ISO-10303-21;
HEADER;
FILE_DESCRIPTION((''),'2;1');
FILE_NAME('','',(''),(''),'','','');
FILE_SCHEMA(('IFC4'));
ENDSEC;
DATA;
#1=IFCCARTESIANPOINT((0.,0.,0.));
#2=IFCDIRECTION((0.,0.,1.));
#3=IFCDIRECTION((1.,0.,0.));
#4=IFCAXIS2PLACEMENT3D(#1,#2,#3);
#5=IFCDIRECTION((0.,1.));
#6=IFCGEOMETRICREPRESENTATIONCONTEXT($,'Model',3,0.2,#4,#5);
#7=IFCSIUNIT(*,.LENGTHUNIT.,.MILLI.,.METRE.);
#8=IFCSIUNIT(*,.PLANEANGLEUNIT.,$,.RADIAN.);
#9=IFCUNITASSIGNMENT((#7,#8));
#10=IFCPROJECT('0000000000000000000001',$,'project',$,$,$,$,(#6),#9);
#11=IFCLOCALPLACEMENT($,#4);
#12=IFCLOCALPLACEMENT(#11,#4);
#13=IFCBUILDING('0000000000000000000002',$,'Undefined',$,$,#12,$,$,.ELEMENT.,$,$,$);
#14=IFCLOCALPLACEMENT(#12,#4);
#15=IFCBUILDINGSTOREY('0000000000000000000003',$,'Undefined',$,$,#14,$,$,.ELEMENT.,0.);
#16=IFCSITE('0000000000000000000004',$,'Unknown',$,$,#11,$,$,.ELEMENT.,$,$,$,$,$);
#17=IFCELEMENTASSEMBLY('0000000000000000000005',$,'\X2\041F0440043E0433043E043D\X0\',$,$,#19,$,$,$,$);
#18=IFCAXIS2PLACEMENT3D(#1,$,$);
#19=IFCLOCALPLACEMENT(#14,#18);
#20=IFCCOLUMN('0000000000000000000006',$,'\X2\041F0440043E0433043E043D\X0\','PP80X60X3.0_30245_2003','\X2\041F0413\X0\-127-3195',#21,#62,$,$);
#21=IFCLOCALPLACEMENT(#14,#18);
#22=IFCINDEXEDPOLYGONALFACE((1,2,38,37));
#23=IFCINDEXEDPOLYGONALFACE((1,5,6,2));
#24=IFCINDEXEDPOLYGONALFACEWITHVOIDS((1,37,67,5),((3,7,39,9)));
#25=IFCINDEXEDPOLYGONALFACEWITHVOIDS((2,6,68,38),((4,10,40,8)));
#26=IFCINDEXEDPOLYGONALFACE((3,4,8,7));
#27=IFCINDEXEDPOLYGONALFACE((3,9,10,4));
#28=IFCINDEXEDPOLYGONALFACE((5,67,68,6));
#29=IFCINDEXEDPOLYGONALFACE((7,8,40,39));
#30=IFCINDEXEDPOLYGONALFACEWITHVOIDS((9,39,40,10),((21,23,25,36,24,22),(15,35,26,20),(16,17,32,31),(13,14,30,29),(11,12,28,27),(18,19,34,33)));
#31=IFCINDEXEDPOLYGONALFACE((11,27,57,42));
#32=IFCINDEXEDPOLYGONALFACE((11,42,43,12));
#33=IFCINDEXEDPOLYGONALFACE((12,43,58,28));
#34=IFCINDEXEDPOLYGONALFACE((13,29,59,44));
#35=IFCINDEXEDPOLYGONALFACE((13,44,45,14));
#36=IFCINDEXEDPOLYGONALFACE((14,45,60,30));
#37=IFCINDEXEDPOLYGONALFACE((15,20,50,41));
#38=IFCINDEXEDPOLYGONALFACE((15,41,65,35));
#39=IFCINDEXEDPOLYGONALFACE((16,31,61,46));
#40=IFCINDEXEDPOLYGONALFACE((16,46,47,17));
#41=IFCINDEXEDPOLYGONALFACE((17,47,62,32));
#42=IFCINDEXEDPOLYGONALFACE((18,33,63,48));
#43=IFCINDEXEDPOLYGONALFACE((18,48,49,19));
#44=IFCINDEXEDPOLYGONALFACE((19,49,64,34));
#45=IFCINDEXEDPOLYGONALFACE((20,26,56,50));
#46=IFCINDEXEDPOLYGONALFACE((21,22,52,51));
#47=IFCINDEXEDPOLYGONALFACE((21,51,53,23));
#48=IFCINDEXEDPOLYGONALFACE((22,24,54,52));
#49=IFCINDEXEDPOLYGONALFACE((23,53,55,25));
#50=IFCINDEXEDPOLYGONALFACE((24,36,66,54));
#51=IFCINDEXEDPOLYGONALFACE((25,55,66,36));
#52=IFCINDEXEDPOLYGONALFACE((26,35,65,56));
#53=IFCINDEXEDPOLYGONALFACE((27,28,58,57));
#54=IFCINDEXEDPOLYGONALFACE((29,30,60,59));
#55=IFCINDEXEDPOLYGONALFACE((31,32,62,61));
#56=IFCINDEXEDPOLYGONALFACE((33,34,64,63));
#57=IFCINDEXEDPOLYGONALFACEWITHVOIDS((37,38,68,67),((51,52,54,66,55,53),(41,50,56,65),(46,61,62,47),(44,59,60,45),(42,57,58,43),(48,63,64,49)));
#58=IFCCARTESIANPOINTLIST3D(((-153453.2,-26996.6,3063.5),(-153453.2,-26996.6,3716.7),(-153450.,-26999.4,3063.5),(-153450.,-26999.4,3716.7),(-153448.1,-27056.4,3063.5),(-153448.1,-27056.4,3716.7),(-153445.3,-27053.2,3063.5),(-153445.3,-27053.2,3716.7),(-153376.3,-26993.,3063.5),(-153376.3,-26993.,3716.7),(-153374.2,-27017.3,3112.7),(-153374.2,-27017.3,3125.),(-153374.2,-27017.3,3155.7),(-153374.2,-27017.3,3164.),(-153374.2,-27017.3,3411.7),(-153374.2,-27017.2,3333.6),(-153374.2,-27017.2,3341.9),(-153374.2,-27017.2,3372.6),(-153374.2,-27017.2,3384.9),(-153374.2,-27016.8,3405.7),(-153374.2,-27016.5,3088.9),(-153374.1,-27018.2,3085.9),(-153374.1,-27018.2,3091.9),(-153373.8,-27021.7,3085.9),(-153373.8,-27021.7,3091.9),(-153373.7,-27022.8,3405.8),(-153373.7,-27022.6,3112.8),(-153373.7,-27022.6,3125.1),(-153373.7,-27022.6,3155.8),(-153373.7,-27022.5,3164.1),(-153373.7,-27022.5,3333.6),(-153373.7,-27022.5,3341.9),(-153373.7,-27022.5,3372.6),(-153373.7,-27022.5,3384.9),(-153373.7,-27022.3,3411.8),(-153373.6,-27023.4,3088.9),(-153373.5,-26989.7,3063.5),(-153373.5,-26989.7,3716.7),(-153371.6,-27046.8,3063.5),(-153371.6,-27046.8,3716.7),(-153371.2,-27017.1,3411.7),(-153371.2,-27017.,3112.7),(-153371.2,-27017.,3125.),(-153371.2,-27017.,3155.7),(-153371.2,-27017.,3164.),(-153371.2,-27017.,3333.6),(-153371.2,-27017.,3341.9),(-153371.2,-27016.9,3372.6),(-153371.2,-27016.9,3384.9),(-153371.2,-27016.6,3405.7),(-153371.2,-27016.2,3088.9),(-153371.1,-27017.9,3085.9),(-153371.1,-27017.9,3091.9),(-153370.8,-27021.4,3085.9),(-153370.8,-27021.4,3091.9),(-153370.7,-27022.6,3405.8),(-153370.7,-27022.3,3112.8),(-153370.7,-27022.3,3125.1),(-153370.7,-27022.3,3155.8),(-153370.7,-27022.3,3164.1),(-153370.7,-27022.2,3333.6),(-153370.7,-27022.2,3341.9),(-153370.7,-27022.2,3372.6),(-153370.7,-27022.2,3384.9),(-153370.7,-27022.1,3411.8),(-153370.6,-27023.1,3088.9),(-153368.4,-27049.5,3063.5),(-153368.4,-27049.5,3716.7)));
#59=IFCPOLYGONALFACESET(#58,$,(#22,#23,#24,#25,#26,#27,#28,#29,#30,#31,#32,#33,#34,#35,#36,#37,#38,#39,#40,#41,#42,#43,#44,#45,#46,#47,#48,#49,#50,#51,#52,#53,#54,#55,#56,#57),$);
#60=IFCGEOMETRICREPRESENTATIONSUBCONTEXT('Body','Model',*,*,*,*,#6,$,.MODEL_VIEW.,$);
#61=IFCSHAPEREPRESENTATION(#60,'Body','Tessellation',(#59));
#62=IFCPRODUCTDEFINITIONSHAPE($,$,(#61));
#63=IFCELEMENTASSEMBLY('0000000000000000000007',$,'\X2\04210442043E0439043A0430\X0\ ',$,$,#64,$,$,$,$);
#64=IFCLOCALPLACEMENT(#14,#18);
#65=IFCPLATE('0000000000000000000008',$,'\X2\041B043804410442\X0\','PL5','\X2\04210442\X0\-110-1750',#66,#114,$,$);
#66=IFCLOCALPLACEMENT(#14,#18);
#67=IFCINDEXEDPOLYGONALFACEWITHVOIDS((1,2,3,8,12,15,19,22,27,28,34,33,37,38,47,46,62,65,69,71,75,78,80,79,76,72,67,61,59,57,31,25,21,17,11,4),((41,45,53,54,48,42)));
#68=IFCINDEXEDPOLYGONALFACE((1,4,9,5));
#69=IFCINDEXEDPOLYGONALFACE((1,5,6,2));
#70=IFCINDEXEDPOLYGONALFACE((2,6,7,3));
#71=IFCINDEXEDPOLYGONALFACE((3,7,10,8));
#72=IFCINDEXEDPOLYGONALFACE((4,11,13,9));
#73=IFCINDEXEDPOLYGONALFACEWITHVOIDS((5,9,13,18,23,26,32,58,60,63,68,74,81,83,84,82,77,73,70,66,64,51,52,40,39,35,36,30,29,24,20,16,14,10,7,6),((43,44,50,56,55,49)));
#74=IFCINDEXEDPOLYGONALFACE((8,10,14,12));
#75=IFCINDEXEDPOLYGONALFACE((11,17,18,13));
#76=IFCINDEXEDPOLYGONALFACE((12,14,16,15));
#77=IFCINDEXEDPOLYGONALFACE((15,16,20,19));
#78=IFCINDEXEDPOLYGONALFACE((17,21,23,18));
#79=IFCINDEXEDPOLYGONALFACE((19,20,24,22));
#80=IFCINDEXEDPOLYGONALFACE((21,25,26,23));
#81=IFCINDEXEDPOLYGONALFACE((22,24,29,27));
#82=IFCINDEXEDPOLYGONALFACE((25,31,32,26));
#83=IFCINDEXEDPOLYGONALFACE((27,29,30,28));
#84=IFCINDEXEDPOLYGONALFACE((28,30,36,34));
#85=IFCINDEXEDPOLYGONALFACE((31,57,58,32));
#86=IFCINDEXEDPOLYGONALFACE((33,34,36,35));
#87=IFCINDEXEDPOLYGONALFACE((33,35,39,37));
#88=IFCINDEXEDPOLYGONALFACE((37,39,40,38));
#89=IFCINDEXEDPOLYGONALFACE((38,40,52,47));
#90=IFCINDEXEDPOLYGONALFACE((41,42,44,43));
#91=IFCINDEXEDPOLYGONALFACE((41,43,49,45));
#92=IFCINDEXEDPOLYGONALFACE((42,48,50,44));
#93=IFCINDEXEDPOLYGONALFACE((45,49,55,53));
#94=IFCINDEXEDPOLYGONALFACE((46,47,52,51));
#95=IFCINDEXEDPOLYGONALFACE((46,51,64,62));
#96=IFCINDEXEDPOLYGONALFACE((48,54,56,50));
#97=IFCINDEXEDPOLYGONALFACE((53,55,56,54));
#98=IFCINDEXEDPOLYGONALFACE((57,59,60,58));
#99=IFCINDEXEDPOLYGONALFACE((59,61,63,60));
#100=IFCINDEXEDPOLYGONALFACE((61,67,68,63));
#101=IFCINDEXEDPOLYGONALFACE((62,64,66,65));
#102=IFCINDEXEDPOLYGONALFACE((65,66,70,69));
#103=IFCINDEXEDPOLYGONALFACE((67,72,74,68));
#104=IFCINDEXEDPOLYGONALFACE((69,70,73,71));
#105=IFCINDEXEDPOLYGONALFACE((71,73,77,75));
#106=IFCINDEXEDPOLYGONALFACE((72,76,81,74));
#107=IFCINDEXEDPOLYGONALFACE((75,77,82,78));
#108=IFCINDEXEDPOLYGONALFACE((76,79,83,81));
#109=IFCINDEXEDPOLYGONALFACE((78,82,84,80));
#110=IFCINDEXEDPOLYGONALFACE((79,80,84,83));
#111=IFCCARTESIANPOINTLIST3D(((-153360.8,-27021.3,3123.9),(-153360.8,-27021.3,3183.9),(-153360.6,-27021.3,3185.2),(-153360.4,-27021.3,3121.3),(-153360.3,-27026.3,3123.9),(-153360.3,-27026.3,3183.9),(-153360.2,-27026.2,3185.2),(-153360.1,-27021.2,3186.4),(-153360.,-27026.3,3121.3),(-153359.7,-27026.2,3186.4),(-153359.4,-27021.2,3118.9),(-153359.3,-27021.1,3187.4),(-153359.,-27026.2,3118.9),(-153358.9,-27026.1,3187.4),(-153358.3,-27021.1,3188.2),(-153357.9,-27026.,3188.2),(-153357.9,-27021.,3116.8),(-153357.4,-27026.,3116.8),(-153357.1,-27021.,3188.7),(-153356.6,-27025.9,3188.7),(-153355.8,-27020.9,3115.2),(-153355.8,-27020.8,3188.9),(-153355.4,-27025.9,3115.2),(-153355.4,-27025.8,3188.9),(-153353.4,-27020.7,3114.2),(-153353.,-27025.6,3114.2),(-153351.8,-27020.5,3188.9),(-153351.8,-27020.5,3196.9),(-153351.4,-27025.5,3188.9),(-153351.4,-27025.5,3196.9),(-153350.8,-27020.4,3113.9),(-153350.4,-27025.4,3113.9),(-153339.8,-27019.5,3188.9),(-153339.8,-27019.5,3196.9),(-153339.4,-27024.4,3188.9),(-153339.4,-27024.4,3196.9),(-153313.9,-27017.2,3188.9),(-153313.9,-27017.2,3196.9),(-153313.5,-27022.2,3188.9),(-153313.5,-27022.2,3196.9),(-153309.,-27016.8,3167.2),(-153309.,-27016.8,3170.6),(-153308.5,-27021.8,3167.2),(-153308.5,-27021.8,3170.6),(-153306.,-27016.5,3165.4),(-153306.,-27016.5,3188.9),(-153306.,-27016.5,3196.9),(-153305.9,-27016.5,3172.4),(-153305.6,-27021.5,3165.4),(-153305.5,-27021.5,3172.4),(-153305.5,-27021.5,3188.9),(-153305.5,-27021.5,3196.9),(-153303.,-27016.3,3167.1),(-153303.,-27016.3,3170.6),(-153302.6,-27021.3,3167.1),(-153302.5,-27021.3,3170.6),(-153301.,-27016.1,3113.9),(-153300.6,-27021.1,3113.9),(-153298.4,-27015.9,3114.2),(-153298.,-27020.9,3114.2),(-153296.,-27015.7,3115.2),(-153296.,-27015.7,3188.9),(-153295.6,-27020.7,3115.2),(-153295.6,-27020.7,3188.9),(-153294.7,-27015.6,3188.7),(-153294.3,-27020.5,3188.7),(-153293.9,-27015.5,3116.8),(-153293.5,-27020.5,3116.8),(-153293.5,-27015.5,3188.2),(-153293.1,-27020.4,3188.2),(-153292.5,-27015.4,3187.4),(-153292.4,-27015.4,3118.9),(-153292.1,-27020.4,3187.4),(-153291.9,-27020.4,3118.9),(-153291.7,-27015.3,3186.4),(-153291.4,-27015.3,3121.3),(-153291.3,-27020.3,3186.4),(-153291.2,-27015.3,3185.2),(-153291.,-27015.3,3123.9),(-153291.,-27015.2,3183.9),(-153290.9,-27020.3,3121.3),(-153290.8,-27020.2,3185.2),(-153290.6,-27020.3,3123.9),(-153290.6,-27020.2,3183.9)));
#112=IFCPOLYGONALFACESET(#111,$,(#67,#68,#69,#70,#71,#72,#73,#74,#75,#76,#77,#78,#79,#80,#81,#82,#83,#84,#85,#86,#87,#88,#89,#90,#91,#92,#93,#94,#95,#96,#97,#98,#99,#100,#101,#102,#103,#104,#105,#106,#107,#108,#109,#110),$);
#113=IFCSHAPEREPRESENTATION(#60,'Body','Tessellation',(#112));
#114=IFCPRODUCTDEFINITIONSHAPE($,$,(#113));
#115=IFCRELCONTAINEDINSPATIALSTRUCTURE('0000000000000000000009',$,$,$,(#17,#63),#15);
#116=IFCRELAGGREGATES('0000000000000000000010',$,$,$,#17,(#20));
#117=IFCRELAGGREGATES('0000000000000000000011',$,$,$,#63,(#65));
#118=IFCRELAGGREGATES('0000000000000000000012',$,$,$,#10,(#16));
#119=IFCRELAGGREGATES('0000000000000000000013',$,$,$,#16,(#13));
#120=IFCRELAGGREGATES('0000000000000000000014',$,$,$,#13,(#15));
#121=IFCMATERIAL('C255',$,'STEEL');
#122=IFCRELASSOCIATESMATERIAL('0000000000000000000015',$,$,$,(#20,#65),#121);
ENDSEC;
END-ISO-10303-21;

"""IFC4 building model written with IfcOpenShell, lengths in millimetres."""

from ifc_helpers import new_model, si_unit, direction, frame, origin_with_axes, place, context, subcontext, project, spatial, line, arc, indexed_curve, outline, extrude, material, element, aggregate, save


model = new_model("IFC4")

# Units and contexts
model_context = context("Model", 3, precision=0.2, world=origin_with_axes(), true_north=direction((0.0, 1.0)))
body_context = subcontext(model_context, "Body", "Model", "MODEL_VIEW")
ifc_project = project(units=[si_unit("LENGTHUNIT", "METRE", prefix="MILLI"), si_unit("PLANEANGLEUNIT", "RADIAN")], contexts=[model_context])

# Site, building, storey
site_placement = place(None, origin_with_axes())
site = spatial("IfcSite", under=ifc_project, at=site_placement, Name="Unknown", CompositionType="ELEMENT")
building_placement = place(site_placement, origin_with_axes())
building = spatial("IfcBuilding", under=site, at=building_placement, Name="Undefined", CompositionType="ELEMENT")
storey_placement = place(building_placement, origin_with_axes())
storey = spatial("IfcBuildingStorey", under=building, at=storey_placement, Name="Undefined", CompositionType="ELEMENT", Elevation=0.0)

# Element assembly, column, voiding features
assembly_1_placement = place(storey_placement, frame((-153410.8, -27023.1, 3063.5), z_axis=(0.086114, -0.996285, 0.0), x_axis=(0.0, 0.0, 1.0)))
assembly_1 = element("IfcElementAssembly", 1, at=assembly_1_placement, inside=storey, Name="Прогон")
ifc_material_1 = material(Name="C255", Category="STEEL")
column_placement = place(assembly_1_placement, origin_with_axes())
column = element("IfcColumn", 2, at=column_placement, material=ifc_material_1, Name="Прогон", Description="PP80X60X3.0_30245_2003", ObjectType="ПГ-127-3195", context=body_context, shape_type="SolidModel", body=[
    extrude(outline(indexed_curve([(-30.0, -40.0), (30.0, -40.0), (30.0, 40.0), (-30.0, 40.0)], segments=[line(1, 2, 3, 4, 1)]), holes=[indexed_curve([(-27.0, -37.0), (-27.0, 37.0), (27.0, 37.0), (27.0, -37.0)], segments=[line(1, 2, 3, 4, 1)])]), frame((0.0, 0.0, 0.0), z_axis=(-1.0, 0.0, 0.0), x_axis=(0.0, 0.0, 1.0)), (0.0, 0.0, -1.0), 653.2),
])
voiding_feature_1_placement = place(column_placement, frame((270.1, -32.0, 0.0), z_axis=(-0.000303, 0.000057, -1.0), x_axis=(1.0, -0.000023, -0.000303)))
element("IfcVoidingFeature", 3, at=voiding_feature_1_placement, cuts=column, Name="CUTPART", ObjectType="(?)", PredefinedType="HOLE", context=body_context, shape_type="SolidModel", body=[
    extrude(outline(indexed_curve([(0.0, 0.0), (8.3, 0.0), (8.3, 9.0), (0.0, 9.0)], segments=[line(1, 2, 3, 4, 1)])), frame((0.0, 0.0, 2.6), z_axis=(0.0, 0.0, 1.0), x_axis=(1.0, 0.0, 0.0)), (0.0, 0.0, -1.0), 5.3),
])
voiding_feature_2_placement = place(column_placement, frame((309.1, -41.0, 0.0), z_axis=(0.000303, -0.000057, 1.0), x_axis=(1.0, -0.000023, -0.000303)))
element("IfcVoidingFeature", 4, at=voiding_feature_2_placement, cuts=column, Name="CUTPART", ObjectType="(?)", PredefinedType="HOLE", context=body_context, shape_type="SolidModel", body=[
    extrude(outline(indexed_curve([(0.0, 0.0), (12.3, 0.0), (12.3, 9.0), (0.0, 9.0)], segments=[line(1, 2, 3, 4, 1)])), frame((0.0, 0.0, 2.6), z_axis=(0.0, 0.0, 1.0), x_axis=(1.0, 0.0, 0.0)), (0.0, 0.0, -1.0), 5.3),
])
voiding_feature_3_placement = place(column_placement, frame((345.2, -50.0, 0.0), z_axis=(0.000303, 0.0, 1.0), x_axis=(0.000024, 1.0, 0.0)))
element("IfcVoidingFeature", 5, at=voiding_feature_3_placement, cuts=column, Name="Балка", ObjectType="(?)", PredefinedType="HOLE", context=body_context, shape_type="SolidModel", body=[
    extrude(outline(indexed_curve([(2.5, -3.0), (3.0, 3.0), (-3.0, 3.0), (-2.5, -3.0)], segments=[line(1, 2, 3, 4, 1)])), frame((0.0, 0.0, 0.0), z_axis=(-1.0, 0.0, 0.0), x_axis=(0.0, 0.0, 1.0)), (0.0, 0.0, -1.0), 20.0),
])
voiding_feature_4_placement = place(column_placement, frame((100.5, -32.0, 0.0), z_axis=(0.000303, 0.000057, 1.0), x_axis=(-1.0, 0.000025, 0.000303)))
element("IfcVoidingFeature", 6, at=voiding_feature_4_placement, cuts=column, Name="CUTPART", ObjectType="(?)", PredefinedType="HOLE", context=body_context, shape_type="SolidModel", body=[
    extrude(outline(indexed_curve([(0.0, 0.0), (8.3, 0.0), (8.3, 9.0), (0.0, 9.0)], segments=[line(1, 2, 3, 4, 1)])), frame((0.0, 0.0, 2.6), z_axis=(0.0, 0.0, 1.0), x_axis=(1.0, 0.0, 0.0)), (0.0, 0.0, -1.0), 5.3),
])
voiding_feature_5_placement = place(column_placement, frame((61.5, -41.0, 0.0), z_axis=(-0.000303, -0.000057, -1.0), x_axis=(-1.0, 0.000025, 0.000303)))
element("IfcVoidingFeature", 7, at=voiding_feature_5_placement, cuts=column, Name="CUTPART", ObjectType="(?)", PredefinedType="HOLE", context=body_context, shape_type="SolidModel", body=[
    extrude(outline(indexed_curve([(0.0, 0.0), (12.3, 0.0), (12.3, 9.0), (0.0, 9.0)], segments=[line(1, 2, 3, 4, 1)])), frame((0.0, 0.0, 2.6), z_axis=(0.0, 0.0, 1.0), x_axis=(1.0, 0.0, 0.0)), (0.0, 0.0, -1.0), 5.3),
])
voiding_feature_6_placement = place(column_placement, frame((25.4, -50.0, 0.0), z_axis=(-0.000303, 0.0, -1.0), x_axis=(0.000024, 1.0, 0.0)))
element("IfcVoidingFeature", 8, at=voiding_feature_6_placement, cuts=column, Name="Балка", ObjectType="(?)", PredefinedType="HOLE", context=body_context, shape_type="SolidModel", body=[
    extrude(outline(indexed_curve([(1.7, -3.0), (3.5, 0.0), (1.7, 3.0), (-1.7, 3.0), (-3.5, 0.0), (-1.7, -3.0)], segments=[line(1, 2, 3, 4, 5, 6, 1)])), frame((0.0, 0.0, 0.0), z_axis=(-1.0, 0.0, 0.0), x_axis=(0.0, 0.0, 1.0)), (0.0, 0.0, -1.0), 20.0),
])
aggregate(assembly_1, [column])

# Element assembly, plate, voiding feature
assembly_2_placement = place(storey_placement, frame((-153388.9, -26231.4, 131.5), z_axis=(-0.086114, 0.996285, 0.0), x_axis=(0.0, 0.0, 1.0)))
assembly_2 = element("IfcElementAssembly", 9, at=assembly_2_placement, inside=storey, Name="Стойка ")
plate_1_placement = place(assembly_2_placement, frame((2982.4, 30.0, -791.9), z_axis=(-0.000357, 0.0, 1.0), x_axis=(0.000078, -1.0, 0.0)))
plate_1 = element("IfcPlate", 10, at=plate_1_placement, material=ifc_material_1, Name="Лист", Description="PL5", ObjectType="Ст-110-1750", context=body_context, shape_type="SolidModel", body=[
    extrude(outline(indexed_curve([(0.0, 10.0), (2.9, 2.9), (10.0, 0.0), (60.0, 0.0), (67.1, 2.9), (70.0, 10.0), (70.0, 70.0), (68.5, 73.5), (65.0, 75.0), (61.0, 75.0), (61.0, 83.0), (49.0, 83.0), (49.0, 75.0), (23.0, 75.0), (23.0, 83.0), (15.0, 83.0), (15.0, 75.0), (5.0, 75.0), (1.5, 73.5), (0.0, 70.0)], segments=[arc(1, 2, 3), line(3, 4), arc(4, 5, 6), line(6, 7), arc(7, 8, 9), line(9, 10, 11, 12, 13, 14, 15, 16, 17, 18), arc(18, 19, 20), line(20, 1)])), frame((0.0, 0.0, 2.5), z_axis=(0.0, 0.0, 1.0), x_axis=(1.0, 0.0, 0.0)), (0.0, 0.0, -1.0), 5.0),
])
voiding_feature_7_placement = place(plate_1_placement, frame((15.0, 55.0, 10.0), z_axis=(0.007997, -0.999968, -0.000026), x_axis=(0.0, 0.000026, -1.0)))
element("IfcVoidingFeature", 11, at=voiding_feature_7_placement, cuts=plate_1, Name="Балка", ObjectType="(?)", PredefinedType="HOLE", context=body_context, shape_type="SolidModel", body=[
    extrude(outline(indexed_curve([(1.7, -3.0), (3.5, 0.0), (1.7, 3.0), (-1.7, 3.0), (-3.5, 0.0), (-1.7, -3.0)], segments=[line(1, 2, 3, 4, 5, 6, 1)])), frame((0.0, 0.0, 0.0), z_axis=(-1.0, 0.0, 0.0), x_axis=(0.0, 0.0, 1.0)), (0.0, 0.0, -1.0), 20.0),
])

aggregate(assembly_2, [plate_1])

save(model, "model.ifc")
